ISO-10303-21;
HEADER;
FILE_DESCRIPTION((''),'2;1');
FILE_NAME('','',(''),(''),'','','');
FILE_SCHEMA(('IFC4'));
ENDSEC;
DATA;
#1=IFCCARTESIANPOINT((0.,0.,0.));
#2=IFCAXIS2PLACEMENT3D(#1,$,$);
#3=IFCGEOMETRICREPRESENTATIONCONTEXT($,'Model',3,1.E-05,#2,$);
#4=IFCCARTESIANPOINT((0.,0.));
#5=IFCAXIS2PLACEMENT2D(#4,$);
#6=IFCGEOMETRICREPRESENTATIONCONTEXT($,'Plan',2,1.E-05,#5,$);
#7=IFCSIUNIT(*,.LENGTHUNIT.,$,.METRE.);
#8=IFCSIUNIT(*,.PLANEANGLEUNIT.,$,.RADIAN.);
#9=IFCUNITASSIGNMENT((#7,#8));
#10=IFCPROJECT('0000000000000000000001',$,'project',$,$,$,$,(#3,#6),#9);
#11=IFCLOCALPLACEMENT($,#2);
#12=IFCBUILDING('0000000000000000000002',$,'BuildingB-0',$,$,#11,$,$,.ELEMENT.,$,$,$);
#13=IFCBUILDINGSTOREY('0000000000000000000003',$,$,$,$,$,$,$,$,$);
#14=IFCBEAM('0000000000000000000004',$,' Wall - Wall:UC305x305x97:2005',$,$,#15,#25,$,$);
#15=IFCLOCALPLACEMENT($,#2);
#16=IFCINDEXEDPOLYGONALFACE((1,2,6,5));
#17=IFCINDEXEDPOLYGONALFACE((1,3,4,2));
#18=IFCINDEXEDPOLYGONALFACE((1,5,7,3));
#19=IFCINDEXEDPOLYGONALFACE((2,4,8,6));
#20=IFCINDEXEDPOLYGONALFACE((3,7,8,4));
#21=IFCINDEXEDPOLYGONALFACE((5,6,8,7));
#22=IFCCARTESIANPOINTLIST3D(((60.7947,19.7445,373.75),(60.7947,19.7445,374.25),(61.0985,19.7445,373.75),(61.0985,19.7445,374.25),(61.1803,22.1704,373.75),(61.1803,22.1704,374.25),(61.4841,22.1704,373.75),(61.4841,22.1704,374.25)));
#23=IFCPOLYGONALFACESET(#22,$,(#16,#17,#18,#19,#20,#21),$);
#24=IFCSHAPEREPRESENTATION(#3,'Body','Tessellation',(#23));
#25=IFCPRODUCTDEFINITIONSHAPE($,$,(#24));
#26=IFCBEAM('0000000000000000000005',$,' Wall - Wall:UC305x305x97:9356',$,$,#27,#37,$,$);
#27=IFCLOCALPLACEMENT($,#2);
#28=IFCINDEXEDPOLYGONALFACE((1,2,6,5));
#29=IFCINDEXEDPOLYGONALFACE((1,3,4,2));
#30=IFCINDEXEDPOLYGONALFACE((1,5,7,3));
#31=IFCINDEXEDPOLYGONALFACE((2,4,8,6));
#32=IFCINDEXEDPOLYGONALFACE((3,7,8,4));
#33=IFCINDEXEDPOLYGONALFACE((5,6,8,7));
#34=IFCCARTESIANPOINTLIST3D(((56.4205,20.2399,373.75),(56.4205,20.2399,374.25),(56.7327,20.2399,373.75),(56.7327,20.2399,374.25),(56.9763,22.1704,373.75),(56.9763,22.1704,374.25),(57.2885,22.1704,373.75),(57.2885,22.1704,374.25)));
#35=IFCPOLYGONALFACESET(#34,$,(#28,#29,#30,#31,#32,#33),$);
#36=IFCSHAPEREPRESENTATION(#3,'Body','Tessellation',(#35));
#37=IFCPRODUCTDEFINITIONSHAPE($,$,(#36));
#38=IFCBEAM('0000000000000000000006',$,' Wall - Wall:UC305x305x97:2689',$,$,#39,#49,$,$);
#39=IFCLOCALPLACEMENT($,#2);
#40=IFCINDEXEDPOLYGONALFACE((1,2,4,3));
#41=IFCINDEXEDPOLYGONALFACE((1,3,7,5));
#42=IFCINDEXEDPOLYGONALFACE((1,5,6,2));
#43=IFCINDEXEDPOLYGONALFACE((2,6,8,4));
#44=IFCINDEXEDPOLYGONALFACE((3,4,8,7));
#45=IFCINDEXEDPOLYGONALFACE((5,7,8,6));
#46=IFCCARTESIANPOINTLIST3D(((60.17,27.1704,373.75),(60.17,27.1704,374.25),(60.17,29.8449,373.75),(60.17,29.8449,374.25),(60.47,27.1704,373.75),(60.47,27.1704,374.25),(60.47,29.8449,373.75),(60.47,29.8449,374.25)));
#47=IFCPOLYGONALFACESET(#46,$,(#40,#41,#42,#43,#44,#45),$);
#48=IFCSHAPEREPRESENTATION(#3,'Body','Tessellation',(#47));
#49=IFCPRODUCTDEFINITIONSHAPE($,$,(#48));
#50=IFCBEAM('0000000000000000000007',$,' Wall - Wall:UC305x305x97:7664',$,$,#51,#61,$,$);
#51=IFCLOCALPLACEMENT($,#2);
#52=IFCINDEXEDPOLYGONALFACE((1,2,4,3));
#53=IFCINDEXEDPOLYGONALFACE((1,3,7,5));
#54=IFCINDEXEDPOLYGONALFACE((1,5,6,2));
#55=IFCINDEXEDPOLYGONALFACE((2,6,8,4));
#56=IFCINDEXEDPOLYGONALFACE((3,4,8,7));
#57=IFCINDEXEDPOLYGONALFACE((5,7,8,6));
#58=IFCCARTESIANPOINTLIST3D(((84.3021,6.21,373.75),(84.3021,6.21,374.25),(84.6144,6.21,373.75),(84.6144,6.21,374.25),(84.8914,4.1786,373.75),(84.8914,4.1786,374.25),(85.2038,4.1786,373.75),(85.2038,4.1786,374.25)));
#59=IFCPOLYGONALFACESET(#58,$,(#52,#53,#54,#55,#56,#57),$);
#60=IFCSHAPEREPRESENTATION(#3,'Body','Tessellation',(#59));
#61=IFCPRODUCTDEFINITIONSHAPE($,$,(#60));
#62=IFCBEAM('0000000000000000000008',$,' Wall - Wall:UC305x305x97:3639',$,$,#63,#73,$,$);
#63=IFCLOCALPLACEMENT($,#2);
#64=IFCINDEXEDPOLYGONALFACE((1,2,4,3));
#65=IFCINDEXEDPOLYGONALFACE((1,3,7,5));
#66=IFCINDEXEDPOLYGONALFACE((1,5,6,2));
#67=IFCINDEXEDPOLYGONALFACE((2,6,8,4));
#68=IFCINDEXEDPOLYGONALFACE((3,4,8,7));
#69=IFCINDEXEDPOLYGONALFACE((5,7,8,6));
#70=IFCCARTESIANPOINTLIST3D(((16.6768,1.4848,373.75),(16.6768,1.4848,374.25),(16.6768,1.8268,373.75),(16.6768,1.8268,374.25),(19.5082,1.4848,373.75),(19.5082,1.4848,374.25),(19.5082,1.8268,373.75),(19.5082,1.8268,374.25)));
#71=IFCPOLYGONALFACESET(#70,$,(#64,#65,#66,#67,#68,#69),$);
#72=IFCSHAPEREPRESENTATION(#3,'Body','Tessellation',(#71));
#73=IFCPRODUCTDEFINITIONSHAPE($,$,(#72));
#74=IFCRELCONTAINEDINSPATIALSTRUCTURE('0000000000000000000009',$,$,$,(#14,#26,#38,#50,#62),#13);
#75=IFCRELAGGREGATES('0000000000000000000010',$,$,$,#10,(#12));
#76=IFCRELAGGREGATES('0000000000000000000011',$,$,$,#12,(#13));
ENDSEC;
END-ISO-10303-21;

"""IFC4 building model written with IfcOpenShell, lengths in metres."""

from ifc_helpers import new_model, si_unit, origin, origin_2d, place, context, project, spatial, polyline, outline, extrude, element, save


model = new_model("IFC4")

# Units and contexts
model_context = context("Model", 3, precision=1e-05, world=origin())
plan_context = context("Plan", 2, precision=1e-05, world=origin_2d())
ifc_project = project(units=[si_unit("LENGTHUNIT", "METRE"), si_unit("PLANEANGLEUNIT", "RADIAN")], contexts=[model_context, plan_context])

# Building, storey
building_placement = place(None, origin())
building = spatial("IfcBuilding", under=ifc_project, at=building_placement, Name="BuildingB-0", CompositionType="ELEMENT")
storey = spatial("IfcBuildingStorey", under=building)

# Beams
element("IfcBeam", 1, inside=storey, Name=" Wall - Wall:UC305x305x97:2005", context=model_context, shape_type="SweptSolid", body=[
    extrude(outline(polyline([(61.0985, 19.7445, 373.75), (60.7947, 19.7445, 373.75), (61.1803, 22.1704, 373.75), (61.4841, 22.1704, 373.75), (61.0985, 19.7445, 373.75)])), None, (0.0, 0.0, 1.0), 0.5),
])
element("IfcBeam", 2, inside=storey, Name=" Wall - Wall:UC305x305x97:9356", context=model_context, shape_type="SweptSolid", body=[
    extrude(outline(polyline([(56.7327, 20.2399, 373.75), (56.4205, 20.2399, 373.75), (56.9763, 22.1704, 373.75), (57.2885, 22.1704, 373.75), (56.7327, 20.2399, 373.75)])), None, (0.0, 0.0, 1.0), 0.5),
])
element("IfcBeam", 3, inside=storey, Name=" Wall - Wall:UC305x305x97:2689", context=model_context, shape_type="SweptSolid", body=[
    extrude(outline(polyline([(60.47, 27.1704, 373.75), (60.17, 27.1704, 373.75), (60.17, 29.8449, 373.75), (60.47, 29.8449, 373.75), (60.47, 27.1704, 373.75)])), None, (0.0, 0.0, 1.0), 0.5),
])
element("IfcBeam", 4, inside=storey, Name=" Wall - Wall:UC305x305x97:7664", context=model_context, shape_type="SweptSolid", body=[
    extrude(outline(polyline([(84.8914, 4.1786, 373.75), (85.2038, 4.1786, 373.75), (84.6144, 6.21, 373.75), (84.3021, 6.21, 373.75), (84.8914, 4.1786, 373.75)])), None, (0.0, 0.0, 1.0), 0.5),
])
element("IfcBeam", 5, inside=storey, Name=" Wall - Wall:UC305x305x97:3639", context=model_context, shape_type="SweptSolid", body=[
    extrude(outline(polyline([(16.6768, 1.4848, 373.75), (19.5082, 1.4848, 373.75), (19.5082, 1.8268, 373.75), (16.6768, 1.8268, 373.75), (16.6768, 1.4848, 373.75)])), None, (0.0, 0.0, 1.0), 0.5),
])

save(model, "model.ifc")
